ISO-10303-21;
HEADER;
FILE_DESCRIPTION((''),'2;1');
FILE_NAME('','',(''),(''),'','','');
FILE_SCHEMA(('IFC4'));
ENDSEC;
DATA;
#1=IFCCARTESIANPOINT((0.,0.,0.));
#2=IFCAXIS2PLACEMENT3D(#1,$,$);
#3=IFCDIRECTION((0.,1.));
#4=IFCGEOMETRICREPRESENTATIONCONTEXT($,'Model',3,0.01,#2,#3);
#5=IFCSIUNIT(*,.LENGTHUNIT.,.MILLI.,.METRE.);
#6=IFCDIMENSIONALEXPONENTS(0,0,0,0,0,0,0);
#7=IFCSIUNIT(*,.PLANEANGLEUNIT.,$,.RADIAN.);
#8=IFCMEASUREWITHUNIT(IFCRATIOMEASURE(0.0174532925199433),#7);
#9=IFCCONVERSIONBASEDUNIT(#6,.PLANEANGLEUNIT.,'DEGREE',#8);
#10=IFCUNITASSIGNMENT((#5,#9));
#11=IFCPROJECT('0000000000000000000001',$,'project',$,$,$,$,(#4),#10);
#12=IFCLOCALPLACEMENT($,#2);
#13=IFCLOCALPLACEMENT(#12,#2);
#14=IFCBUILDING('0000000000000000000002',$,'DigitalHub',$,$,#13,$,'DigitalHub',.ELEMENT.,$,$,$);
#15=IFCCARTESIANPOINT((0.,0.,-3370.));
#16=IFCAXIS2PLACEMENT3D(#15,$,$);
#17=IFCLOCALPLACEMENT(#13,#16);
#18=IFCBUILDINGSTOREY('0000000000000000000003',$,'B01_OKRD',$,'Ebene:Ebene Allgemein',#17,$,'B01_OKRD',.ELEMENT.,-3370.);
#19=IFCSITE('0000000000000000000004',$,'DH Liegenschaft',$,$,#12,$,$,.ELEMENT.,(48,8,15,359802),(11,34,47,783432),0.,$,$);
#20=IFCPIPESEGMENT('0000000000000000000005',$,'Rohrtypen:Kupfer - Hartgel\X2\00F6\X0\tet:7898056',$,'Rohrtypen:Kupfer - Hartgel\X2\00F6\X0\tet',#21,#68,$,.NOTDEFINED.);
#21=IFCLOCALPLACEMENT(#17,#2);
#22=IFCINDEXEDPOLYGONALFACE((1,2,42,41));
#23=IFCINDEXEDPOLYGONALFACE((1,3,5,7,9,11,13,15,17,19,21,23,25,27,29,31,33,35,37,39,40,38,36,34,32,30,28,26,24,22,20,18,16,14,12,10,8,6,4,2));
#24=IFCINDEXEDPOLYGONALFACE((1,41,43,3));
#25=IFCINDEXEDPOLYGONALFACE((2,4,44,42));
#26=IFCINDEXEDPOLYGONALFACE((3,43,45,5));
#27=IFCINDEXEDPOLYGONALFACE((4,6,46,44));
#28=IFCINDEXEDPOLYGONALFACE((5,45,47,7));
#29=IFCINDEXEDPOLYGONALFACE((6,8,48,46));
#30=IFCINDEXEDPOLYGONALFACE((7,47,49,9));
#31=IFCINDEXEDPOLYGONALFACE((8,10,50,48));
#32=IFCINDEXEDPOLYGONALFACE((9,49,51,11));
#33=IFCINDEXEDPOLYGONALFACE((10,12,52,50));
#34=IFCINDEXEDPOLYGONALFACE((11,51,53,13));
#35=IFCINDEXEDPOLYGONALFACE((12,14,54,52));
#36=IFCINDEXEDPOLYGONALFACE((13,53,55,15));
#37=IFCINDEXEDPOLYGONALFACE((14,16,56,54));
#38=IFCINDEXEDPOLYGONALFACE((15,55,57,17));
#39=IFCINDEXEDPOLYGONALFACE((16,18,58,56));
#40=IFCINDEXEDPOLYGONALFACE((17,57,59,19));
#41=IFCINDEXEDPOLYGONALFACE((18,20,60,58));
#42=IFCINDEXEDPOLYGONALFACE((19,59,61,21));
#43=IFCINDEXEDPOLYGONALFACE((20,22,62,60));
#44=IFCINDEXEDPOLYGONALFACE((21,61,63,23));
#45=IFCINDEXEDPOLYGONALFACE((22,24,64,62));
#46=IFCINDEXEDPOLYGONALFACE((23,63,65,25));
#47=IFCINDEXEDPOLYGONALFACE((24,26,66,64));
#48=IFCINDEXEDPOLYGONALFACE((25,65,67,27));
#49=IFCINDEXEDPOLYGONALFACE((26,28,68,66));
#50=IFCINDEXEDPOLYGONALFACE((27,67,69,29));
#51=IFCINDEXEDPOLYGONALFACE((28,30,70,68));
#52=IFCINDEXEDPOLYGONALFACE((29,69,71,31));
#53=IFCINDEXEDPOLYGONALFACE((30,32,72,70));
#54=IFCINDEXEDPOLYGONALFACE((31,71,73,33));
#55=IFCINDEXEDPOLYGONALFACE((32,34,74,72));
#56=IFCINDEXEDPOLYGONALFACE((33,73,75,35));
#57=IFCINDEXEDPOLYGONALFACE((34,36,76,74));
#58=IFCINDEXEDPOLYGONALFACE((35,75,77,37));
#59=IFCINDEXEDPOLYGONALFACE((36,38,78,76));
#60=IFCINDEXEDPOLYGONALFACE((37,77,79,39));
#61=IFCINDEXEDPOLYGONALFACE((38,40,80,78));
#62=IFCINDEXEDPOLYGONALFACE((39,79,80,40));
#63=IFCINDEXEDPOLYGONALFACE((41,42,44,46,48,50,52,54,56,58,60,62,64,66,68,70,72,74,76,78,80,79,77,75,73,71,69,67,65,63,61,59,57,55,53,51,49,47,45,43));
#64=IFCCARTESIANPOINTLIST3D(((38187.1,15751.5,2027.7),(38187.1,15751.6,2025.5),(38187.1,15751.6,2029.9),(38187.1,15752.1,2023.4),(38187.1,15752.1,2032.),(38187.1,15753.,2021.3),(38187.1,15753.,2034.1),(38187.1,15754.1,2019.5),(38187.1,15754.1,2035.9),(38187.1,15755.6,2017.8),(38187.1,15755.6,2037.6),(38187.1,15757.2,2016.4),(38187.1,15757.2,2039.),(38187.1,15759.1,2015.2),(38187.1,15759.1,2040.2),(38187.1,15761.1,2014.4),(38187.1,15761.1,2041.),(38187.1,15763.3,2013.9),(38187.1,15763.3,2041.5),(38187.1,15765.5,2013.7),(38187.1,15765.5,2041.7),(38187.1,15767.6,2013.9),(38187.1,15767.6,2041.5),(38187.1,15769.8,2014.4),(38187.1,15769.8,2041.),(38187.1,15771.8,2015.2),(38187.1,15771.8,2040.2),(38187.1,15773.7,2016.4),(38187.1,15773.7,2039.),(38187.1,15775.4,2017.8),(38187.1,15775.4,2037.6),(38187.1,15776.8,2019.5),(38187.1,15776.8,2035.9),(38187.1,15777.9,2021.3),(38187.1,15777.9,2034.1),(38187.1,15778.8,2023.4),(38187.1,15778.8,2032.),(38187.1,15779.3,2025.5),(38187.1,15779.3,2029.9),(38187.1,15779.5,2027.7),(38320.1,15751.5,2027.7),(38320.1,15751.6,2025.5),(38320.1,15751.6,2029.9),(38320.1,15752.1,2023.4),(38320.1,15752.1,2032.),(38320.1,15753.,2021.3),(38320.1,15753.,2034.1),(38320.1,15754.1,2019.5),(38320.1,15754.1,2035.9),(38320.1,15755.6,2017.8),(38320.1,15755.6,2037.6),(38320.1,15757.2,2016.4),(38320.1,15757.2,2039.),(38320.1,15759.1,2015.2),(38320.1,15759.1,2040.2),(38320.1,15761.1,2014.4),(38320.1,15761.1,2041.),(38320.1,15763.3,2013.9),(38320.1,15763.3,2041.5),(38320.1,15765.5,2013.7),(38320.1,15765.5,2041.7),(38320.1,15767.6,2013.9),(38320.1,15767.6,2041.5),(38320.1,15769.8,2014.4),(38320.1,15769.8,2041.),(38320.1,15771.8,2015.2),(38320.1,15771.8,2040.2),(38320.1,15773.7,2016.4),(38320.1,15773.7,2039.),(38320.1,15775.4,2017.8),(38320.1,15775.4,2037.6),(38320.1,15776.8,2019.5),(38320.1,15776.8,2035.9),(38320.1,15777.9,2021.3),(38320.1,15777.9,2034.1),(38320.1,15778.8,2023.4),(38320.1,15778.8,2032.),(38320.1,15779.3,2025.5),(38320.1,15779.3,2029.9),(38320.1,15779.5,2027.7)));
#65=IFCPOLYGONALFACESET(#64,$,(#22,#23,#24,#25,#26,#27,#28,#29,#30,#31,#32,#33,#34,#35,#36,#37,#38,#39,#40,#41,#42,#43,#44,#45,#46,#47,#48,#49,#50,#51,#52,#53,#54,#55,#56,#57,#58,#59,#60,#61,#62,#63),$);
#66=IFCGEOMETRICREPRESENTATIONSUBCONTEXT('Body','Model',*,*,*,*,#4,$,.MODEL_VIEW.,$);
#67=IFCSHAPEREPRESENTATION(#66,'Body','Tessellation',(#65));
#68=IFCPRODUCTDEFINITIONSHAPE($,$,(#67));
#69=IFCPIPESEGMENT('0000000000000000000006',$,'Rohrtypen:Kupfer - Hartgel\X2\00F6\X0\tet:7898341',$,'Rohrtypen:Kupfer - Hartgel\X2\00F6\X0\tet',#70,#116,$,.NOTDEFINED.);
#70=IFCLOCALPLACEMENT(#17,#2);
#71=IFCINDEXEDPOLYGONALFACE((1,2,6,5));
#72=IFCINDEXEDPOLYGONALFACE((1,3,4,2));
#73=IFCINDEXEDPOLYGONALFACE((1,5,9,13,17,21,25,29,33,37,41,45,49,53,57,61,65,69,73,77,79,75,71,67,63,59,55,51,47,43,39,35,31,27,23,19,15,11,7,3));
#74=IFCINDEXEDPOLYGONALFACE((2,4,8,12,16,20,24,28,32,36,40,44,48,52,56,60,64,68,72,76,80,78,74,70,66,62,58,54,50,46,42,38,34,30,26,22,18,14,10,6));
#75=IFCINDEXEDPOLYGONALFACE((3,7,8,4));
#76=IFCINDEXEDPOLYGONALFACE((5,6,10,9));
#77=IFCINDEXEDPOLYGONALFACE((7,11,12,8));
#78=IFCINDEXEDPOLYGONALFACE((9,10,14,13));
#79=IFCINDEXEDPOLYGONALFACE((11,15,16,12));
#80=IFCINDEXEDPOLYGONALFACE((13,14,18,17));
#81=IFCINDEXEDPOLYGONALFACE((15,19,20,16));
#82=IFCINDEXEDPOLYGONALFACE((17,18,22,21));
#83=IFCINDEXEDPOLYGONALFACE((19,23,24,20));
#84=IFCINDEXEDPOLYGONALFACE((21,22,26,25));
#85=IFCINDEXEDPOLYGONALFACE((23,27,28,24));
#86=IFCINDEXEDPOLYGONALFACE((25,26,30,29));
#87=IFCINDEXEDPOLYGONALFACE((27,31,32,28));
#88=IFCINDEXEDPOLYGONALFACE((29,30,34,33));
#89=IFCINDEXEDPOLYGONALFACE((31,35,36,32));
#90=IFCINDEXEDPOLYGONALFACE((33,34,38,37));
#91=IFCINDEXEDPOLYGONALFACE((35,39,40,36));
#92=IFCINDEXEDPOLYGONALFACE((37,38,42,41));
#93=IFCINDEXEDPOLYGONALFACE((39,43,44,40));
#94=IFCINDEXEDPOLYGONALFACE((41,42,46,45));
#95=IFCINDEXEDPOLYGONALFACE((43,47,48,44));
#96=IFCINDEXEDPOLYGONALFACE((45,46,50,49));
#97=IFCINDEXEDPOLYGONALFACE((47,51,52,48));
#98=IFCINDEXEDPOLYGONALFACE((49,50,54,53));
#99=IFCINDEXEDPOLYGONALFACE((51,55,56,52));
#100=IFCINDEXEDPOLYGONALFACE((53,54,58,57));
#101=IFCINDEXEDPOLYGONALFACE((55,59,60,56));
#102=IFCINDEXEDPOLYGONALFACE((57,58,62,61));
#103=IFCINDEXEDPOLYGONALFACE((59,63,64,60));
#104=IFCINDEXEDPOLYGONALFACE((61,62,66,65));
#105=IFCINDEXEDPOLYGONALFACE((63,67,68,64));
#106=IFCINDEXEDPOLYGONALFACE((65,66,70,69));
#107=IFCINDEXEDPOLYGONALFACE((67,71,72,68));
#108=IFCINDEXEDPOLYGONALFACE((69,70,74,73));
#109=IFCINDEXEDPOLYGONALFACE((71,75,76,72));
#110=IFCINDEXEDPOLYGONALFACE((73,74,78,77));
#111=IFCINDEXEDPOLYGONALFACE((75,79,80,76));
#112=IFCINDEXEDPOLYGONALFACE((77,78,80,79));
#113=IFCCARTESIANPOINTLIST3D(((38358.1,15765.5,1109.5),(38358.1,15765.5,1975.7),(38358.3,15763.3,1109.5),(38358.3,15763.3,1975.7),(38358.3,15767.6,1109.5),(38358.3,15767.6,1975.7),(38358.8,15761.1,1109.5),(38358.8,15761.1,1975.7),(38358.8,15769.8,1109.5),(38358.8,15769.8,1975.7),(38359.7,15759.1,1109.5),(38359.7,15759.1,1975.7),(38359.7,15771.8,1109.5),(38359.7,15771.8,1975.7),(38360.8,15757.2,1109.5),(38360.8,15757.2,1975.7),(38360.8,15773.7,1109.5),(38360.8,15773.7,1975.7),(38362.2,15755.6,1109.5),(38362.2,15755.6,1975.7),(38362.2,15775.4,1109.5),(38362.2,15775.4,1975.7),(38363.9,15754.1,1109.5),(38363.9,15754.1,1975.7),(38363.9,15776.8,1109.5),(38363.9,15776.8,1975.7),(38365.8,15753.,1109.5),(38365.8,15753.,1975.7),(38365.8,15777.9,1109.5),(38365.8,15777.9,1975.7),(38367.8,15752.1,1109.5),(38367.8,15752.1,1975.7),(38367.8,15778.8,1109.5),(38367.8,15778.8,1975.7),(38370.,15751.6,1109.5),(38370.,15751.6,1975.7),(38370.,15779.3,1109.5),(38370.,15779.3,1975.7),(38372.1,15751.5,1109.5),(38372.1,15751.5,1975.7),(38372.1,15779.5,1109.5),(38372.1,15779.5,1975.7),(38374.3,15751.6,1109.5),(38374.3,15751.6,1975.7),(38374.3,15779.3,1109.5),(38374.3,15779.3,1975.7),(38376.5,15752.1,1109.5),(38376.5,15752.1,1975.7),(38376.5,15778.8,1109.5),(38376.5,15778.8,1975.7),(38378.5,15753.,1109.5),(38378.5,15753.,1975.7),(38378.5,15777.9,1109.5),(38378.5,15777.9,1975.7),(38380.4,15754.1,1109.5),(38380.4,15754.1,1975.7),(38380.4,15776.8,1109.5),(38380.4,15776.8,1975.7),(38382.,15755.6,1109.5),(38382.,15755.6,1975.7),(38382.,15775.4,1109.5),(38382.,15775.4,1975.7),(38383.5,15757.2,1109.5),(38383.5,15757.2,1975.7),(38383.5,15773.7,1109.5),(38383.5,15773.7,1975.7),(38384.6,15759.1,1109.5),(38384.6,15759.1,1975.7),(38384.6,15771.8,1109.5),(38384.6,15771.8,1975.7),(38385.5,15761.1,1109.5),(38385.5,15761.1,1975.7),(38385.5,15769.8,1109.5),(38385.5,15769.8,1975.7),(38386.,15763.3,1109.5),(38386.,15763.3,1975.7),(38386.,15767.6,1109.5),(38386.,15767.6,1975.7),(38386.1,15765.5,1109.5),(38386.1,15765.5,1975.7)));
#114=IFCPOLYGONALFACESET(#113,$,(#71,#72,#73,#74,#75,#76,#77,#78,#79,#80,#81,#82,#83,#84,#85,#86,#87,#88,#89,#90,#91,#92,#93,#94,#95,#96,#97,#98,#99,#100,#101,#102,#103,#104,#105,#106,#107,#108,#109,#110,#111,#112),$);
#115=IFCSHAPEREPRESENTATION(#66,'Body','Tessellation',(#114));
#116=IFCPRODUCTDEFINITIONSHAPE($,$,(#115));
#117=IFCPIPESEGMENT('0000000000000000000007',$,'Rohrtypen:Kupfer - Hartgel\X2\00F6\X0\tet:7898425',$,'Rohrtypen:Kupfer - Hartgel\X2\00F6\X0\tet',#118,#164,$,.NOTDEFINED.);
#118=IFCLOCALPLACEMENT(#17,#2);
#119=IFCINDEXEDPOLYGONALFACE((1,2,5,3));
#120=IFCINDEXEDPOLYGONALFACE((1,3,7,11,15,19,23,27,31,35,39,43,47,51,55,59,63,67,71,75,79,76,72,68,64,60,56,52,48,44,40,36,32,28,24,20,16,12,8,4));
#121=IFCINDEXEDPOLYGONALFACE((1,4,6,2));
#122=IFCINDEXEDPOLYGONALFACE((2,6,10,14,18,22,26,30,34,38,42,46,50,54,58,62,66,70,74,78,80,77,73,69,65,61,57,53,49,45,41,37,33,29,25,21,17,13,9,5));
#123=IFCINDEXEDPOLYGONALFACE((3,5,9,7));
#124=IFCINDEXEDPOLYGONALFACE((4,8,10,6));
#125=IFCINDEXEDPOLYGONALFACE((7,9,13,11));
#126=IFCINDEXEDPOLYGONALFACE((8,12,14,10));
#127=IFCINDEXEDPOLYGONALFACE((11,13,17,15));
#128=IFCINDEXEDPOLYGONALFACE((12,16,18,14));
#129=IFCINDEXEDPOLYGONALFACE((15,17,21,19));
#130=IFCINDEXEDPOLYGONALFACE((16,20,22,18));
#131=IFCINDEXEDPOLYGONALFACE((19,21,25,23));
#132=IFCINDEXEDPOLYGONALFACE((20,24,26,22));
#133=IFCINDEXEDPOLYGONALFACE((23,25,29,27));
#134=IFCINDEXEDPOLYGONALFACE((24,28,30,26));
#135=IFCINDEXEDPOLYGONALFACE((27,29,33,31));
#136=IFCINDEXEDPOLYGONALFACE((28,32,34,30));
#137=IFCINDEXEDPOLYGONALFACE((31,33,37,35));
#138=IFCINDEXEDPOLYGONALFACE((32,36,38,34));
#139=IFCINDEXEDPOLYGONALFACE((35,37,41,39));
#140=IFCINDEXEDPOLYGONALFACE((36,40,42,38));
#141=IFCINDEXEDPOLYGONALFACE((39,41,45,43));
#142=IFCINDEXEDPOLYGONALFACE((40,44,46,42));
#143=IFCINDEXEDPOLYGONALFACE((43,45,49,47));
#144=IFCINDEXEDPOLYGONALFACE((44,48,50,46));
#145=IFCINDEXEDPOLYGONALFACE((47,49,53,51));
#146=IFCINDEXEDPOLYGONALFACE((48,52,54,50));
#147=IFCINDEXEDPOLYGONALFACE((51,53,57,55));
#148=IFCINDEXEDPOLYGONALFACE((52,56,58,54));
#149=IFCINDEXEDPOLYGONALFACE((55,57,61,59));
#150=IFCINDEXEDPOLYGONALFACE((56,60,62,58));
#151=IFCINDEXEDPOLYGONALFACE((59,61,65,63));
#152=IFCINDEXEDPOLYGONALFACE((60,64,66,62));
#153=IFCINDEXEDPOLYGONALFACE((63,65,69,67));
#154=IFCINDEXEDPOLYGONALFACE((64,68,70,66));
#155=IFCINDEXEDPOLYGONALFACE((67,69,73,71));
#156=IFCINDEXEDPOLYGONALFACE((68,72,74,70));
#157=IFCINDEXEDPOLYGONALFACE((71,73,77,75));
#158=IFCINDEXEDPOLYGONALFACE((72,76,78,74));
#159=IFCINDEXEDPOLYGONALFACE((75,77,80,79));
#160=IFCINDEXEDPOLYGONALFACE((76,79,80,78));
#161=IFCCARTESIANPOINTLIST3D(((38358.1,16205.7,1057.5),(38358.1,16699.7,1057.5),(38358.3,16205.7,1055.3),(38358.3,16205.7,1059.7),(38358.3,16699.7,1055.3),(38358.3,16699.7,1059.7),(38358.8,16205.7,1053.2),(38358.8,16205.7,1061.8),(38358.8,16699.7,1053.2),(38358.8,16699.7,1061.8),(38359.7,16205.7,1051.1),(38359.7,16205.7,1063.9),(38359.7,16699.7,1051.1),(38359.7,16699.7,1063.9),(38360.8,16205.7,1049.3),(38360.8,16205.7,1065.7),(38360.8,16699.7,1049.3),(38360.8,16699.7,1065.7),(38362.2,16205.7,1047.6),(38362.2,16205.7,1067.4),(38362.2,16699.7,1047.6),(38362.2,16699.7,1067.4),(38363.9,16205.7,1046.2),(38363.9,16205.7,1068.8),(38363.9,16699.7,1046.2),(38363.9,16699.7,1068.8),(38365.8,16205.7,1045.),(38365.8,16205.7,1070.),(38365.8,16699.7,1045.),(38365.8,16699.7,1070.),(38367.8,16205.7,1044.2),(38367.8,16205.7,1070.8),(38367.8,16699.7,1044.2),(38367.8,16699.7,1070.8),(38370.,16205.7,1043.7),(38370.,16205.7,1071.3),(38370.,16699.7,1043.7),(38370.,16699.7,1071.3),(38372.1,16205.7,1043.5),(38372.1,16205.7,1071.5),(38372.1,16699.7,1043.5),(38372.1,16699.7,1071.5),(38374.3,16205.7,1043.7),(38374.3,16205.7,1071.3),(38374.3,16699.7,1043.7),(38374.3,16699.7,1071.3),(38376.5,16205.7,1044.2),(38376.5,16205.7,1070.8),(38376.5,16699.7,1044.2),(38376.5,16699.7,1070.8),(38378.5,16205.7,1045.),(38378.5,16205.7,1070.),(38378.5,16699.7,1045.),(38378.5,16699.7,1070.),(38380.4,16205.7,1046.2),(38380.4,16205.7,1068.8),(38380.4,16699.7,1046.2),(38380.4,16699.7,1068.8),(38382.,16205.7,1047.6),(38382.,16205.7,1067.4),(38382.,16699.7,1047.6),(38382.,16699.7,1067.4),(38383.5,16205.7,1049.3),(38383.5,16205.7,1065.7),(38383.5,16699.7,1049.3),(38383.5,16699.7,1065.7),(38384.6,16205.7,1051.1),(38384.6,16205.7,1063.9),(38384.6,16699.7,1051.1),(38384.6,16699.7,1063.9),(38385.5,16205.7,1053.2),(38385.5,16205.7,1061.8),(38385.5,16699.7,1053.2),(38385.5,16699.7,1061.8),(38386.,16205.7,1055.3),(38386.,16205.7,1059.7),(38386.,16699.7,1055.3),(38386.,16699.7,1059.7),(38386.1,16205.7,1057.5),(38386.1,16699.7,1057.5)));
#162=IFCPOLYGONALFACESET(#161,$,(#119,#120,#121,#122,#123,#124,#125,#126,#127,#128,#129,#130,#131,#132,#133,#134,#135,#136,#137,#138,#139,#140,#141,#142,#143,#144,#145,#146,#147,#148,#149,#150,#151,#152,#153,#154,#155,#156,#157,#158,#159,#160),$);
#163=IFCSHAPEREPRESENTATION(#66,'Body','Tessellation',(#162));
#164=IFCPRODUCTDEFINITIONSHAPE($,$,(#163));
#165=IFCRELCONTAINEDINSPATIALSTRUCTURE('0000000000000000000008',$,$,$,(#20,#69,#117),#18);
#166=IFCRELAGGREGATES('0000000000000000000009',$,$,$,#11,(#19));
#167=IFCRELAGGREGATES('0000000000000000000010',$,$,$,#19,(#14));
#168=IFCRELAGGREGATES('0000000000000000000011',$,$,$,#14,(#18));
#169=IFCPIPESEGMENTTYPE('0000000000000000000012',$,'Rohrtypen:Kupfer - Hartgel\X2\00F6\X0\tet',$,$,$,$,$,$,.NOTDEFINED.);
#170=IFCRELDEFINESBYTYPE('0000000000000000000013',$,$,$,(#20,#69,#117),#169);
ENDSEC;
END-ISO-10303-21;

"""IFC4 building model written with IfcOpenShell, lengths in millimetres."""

from ifc_helpers import new_model, entity, si_unit, converted_unit, direction, frame, origin, place, context, subcontext, project, spatial, indexed_curve, outline, extrude, type_object, element, save


model = new_model("IFC4")

# Units and contexts
model_context = context("Model", 3, precision=0.01, world=origin(), true_north=direction((0.0, 1.0)))
body_context = subcontext(model_context, "Body", "Model", "MODEL_VIEW")
ifc_project = project(units=[si_unit("LENGTHUNIT", "METRE", prefix="MILLI"), converted_unit("PLANEANGLEUNIT", "DEGREE", entity("IfcRatioMeasure", 0.0174532925199433), si_unit("PLANEANGLEUNIT", "RADIAN"), dimensions=[0, 0, 0, 0, 0, 0, 0])], contexts=[model_context])

# Site, building, storey
site_placement = place(None, origin())
site = spatial("IfcSite", under=ifc_project, at=site_placement, Name="DH Liegenschaft", CompositionType="ELEMENT", RefLatitude=(48, 8, 15, 359802), RefLongitude=(11, 34, 47, 783432), RefElevation=0.0)
building_placement = place(site_placement, origin())
building = spatial("IfcBuilding", under=site, at=building_placement, Name="DigitalHub", LongName="DigitalHub", CompositionType="ELEMENT")
storey_placement = place(building_placement, frame((0.0, 0.0, -3370.0)))
storey = spatial("IfcBuildingStorey", under=building, at=storey_placement, Name="B01_OKRD", ObjectType="Ebene:Ebene Allgemein", LongName="B01_OKRD", CompositionType="ELEMENT", Elevation=-3370.0)

# Pipe segments
pipe_segment_type = type_object("IfcPipeSegmentType", Name="Rohrtypen:Kupfer - Hartgelötet", PredefinedType="NOTDEFINED")
pipe_segment_1_placement = place(storey_placement, frame((38187.1, 15749.9, 2012.1)))
element("IfcPipeSegment", 1, at=pipe_segment_1_placement, inside=storey, type_object=pipe_segment_type, Name="Rohrtypen:Kupfer - Hartgelötet:7898056", ObjectType="Rohrtypen:Kupfer - Hartgelötet", PredefinedType="NOTDEFINED", context=body_context, shape_type="SweptSolid", body=[
    extrude(outline(indexed_curve([(14.0, 0.0), (13.8, 2.2), (13.3, 4.3), (12.5, 6.4), (11.3, 8.2), (9.9, 9.9), (8.2, 11.3), (6.4, 12.5), (4.3, 13.3), (2.2, 13.8), (0.0, 14.0), (-2.2, 13.8), (-4.3, 13.3), (-6.4, 12.5), (-8.2, 11.3), (-9.9, 9.9), (-11.3, 8.2), (-12.5, 6.4), (-13.3, 4.3), (-13.8, 2.2), (-14.0, 0.0), (-13.8, -2.2), (-13.3, -4.3), (-12.5, -6.4), (-11.3, -8.2), (-9.9, -9.9), (-8.2, -11.3), (-6.4, -12.5), (-4.3, -13.3), (-2.2, -13.8), (0.0, -14.0), (2.2, -13.8), (4.3, -13.3), (6.4, -12.5), (8.2, -11.3), (9.9, -9.9), (11.3, -8.2), (12.5, -6.4), (13.3, -4.3), (13.8, -2.2), (14.0, 0.0)], self_intersect=False)), frame((0.0, 15.6, 15.6), z_axis=(1.0, 0.0, 0.0), x_axis=(0.0, -1.0, 0.0)), (0.0, 0.0, 1.0), 133.0),
])
pipe_segment_2_placement = place(storey_placement, frame((38356.6, 15749.9, 1109.5)))
element("IfcPipeSegment", 2, at=pipe_segment_2_placement, inside=storey, type_object=pipe_segment_type, Name="Rohrtypen:Kupfer - Hartgelötet:7898341", ObjectType="Rohrtypen:Kupfer - Hartgelötet", PredefinedType="NOTDEFINED", context=body_context, shape_type="SweptSolid", body=[
    extrude(outline(indexed_curve([(14.0, 0.0), (13.8, 2.2), (13.3, 4.3), (12.5, 6.4), (11.3, 8.2), (9.9, 9.9), (8.2, 11.3), (6.4, 12.5), (4.3, 13.3), (2.2, 13.8), (0.0, 14.0), (-2.2, 13.8), (-4.3, 13.3), (-6.4, 12.5), (-8.2, 11.3), (-9.9, 9.9), (-11.3, 8.2), (-12.5, 6.4), (-13.3, 4.3), (-13.8, 2.2), (-14.0, 0.0), (-13.8, -2.2), (-13.3, -4.3), (-12.5, -6.4), (-11.3, -8.2), (-9.9, -9.9), (-8.2, -11.3), (-6.4, -12.5), (-4.3, -13.3), (-2.2, -13.8), (0.0, -14.0), (2.2, -13.8), (4.3, -13.3), (6.4, -12.5), (8.2, -11.3), (9.9, -9.9), (11.3, -8.2), (12.5, -6.4), (13.3, -4.3), (13.8, -2.2), (14.0, 0.0)], self_intersect=False)), frame((15.6, 15.6, 0.0)), (0.0, 0.0, 1.0), 866.2),
])
pipe_segment_3_placement = place(storey_placement, frame((38356.6, 16205.7, 1041.9)))
element("IfcPipeSegment", 3, at=pipe_segment_3_placement, inside=storey, type_object=pipe_segment_type, Name="Rohrtypen:Kupfer - Hartgelötet:7898425", ObjectType="Rohrtypen:Kupfer - Hartgelötet", PredefinedType="NOTDEFINED", context=body_context, shape_type="SweptSolid", body=[
    extrude(outline(indexed_curve([(14.0, 0.0), (13.8, 2.2), (13.3, 4.3), (12.5, 6.4), (11.3, 8.2), (9.9, 9.9), (8.2, 11.3), (6.4, 12.5), (4.3, 13.3), (2.2, 13.8), (0.0, 14.0), (-2.2, 13.8), (-4.3, 13.3), (-6.4, 12.5), (-8.2, 11.3), (-9.9, 9.9), (-11.3, 8.2), (-12.5, 6.4), (-13.3, 4.3), (-13.8, 2.2), (-14.0, 0.0), (-13.8, -2.2), (-13.3, -4.3), (-12.5, -6.4), (-11.3, -8.2), (-9.9, -9.9), (-8.2, -11.3), (-6.4, -12.5), (-4.3, -13.3), (-2.2, -13.8), (0.0, -14.0), (2.2, -13.8), (4.3, -13.3), (6.4, -12.5), (8.2, -11.3), (9.9, -9.9), (11.3, -8.2), (12.5, -6.4), (13.3, -4.3), (13.8, -2.2), (14.0, 0.0)], self_intersect=False)), frame((15.6, 0.0, 15.6), z_axis=(0.0, 1.0, 0.0), x_axis=(1.0, 0.0, 0.0)), (0.0, 0.0, 1.0), 494.0),
])

save(model, "model.ifc")
